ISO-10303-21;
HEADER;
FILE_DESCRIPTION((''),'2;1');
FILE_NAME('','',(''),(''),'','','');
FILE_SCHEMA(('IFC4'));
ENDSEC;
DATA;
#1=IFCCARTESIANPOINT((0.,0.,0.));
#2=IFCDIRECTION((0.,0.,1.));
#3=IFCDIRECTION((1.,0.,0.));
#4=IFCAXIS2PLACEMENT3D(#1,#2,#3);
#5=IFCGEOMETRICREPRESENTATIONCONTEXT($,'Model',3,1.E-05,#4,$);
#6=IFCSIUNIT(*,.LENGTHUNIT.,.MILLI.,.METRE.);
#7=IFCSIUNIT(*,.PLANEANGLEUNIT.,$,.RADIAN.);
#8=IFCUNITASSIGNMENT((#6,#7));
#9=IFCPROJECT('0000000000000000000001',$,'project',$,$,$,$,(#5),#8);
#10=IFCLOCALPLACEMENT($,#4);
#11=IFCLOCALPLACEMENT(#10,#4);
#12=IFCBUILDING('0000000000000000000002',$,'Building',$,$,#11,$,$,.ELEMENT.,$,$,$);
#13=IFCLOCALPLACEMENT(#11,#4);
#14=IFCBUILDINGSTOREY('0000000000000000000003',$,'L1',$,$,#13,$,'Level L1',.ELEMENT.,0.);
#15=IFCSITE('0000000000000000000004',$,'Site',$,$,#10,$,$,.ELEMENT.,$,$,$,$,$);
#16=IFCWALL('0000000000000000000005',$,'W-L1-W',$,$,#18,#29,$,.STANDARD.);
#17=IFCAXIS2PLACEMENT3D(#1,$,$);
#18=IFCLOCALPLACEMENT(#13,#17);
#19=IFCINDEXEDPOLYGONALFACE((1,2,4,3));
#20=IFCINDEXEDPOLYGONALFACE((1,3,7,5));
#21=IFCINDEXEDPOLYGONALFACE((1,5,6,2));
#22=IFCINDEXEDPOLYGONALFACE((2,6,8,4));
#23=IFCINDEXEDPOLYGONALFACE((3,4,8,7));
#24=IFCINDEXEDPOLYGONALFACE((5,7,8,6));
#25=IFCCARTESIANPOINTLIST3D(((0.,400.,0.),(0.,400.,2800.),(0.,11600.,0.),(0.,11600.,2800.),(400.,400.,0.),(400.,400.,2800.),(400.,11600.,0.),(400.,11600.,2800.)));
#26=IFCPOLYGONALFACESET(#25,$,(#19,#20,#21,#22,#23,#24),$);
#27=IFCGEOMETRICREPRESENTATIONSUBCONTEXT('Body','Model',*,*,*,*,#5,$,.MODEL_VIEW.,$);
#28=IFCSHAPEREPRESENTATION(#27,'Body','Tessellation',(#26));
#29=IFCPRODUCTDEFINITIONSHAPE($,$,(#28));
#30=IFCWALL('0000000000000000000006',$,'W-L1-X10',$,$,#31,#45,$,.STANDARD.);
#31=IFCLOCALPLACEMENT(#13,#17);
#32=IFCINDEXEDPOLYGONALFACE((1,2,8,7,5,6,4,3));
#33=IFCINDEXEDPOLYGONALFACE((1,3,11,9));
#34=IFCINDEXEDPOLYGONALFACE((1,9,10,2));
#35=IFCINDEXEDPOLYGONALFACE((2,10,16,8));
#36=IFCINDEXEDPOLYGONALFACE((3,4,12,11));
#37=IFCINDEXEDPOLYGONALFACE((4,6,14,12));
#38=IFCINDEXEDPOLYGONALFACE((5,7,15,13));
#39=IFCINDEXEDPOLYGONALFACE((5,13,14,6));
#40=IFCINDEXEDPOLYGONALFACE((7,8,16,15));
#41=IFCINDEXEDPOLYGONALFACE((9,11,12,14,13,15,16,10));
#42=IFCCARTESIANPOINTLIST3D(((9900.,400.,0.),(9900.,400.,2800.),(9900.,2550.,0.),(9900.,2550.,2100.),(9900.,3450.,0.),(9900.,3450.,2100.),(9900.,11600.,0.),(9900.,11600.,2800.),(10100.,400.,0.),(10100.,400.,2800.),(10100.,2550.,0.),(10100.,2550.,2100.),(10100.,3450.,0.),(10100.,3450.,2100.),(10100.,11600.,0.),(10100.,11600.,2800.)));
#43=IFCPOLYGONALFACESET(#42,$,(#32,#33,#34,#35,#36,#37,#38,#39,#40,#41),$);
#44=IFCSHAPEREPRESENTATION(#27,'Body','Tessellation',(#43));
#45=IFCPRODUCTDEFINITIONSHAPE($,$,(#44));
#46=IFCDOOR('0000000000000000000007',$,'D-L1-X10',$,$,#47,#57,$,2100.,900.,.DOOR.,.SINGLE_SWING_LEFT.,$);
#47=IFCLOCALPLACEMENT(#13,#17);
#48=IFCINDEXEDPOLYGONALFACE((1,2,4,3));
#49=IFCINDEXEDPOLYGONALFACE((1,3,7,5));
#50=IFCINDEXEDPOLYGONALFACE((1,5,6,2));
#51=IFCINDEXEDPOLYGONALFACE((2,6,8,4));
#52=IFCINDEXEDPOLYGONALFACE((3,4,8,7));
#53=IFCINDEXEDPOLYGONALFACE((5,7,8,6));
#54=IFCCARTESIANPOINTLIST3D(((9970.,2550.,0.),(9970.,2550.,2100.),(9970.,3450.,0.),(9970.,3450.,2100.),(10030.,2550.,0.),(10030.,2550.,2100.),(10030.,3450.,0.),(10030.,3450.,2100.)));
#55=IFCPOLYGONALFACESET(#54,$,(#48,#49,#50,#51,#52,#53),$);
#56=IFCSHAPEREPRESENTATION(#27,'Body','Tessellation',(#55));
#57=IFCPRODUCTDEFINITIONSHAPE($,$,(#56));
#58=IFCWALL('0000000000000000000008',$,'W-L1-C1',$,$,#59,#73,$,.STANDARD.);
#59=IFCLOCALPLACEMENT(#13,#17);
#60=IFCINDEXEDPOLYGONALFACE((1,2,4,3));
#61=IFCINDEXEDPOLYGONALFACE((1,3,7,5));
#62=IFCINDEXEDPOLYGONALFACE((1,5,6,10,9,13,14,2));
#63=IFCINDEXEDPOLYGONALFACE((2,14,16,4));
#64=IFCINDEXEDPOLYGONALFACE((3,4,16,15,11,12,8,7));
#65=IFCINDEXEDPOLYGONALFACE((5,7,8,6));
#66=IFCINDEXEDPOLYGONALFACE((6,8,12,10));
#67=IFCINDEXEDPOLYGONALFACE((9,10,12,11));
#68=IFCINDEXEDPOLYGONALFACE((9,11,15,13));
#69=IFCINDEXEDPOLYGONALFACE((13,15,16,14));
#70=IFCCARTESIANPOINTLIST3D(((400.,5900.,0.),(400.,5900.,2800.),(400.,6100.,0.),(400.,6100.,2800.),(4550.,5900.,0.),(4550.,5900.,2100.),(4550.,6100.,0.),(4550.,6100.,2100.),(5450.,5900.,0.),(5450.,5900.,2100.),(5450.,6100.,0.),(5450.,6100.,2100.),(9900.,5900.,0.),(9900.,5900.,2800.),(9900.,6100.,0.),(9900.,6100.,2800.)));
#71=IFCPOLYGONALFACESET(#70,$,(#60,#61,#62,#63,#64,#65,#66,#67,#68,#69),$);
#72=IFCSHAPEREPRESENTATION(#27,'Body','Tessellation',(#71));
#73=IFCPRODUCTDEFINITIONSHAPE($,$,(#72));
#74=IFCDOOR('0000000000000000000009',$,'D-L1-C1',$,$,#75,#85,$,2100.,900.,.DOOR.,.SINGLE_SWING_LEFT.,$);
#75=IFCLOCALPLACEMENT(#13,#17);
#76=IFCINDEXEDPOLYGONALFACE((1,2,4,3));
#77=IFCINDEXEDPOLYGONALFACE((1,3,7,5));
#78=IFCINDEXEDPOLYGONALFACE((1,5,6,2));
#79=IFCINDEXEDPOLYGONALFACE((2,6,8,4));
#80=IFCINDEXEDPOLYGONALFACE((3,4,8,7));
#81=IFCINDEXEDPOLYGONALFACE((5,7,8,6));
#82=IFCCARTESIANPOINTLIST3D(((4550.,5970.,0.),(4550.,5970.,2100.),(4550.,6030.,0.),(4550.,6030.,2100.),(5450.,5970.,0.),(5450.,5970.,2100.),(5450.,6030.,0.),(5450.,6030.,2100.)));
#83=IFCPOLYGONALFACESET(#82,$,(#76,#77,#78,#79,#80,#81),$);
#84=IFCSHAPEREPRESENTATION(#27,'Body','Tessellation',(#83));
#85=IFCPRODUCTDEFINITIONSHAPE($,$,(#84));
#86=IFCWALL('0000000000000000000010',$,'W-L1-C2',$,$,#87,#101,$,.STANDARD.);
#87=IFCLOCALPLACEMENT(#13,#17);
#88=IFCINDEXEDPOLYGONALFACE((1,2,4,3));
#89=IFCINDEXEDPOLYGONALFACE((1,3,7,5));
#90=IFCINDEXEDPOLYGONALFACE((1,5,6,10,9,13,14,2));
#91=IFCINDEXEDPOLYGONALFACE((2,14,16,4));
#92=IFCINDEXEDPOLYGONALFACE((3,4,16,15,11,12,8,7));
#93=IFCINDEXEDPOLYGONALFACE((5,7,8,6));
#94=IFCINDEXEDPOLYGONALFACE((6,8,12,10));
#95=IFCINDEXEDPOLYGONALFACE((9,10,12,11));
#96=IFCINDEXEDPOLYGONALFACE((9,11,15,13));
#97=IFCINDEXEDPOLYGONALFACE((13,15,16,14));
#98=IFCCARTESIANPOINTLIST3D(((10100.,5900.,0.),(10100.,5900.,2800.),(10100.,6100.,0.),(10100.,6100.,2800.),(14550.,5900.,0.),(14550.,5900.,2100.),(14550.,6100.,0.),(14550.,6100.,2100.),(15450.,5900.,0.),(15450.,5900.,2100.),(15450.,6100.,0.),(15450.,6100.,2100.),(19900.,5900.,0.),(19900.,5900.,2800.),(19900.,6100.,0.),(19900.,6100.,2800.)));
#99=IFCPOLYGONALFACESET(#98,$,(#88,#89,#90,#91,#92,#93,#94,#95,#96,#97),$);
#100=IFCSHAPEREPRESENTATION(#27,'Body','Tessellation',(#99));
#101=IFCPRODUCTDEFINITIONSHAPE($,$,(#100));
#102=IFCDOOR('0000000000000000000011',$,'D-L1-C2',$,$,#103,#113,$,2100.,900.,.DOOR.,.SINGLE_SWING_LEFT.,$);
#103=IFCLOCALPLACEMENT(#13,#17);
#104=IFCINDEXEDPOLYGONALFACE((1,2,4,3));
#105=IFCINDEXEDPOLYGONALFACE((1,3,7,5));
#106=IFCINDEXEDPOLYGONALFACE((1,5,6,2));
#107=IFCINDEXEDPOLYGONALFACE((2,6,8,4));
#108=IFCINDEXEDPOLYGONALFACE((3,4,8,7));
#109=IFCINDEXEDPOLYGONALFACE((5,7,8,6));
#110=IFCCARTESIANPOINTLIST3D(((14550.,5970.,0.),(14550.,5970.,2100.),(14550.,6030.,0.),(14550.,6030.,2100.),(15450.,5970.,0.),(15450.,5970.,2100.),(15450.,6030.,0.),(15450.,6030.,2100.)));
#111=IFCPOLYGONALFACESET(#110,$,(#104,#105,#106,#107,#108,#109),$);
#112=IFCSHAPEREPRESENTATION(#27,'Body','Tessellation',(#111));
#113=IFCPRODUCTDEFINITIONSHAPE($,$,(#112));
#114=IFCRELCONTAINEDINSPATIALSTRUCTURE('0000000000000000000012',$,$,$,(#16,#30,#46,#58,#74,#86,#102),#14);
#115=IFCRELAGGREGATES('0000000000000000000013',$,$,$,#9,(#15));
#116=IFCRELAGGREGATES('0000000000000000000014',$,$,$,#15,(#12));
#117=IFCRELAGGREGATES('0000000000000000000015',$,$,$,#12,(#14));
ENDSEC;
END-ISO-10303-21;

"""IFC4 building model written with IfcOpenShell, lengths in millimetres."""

from ifc_helpers import new_model, si_unit, frame, origin_with_axes, origin_2d, place, context, subcontext, project, spatial, rectangle, extrude, element, fill, save


model = new_model("IFC4")

# Units and contexts
model_context = context("Model", 3, precision=1e-05, world=origin_with_axes())
body_context = subcontext(model_context, "Body", "Model", "MODEL_VIEW")
ifc_project = project(units=[si_unit("LENGTHUNIT", "METRE", prefix="MILLI"), si_unit("PLANEANGLEUNIT", "RADIAN")], contexts=[model_context])

# Site, building, storey
site_placement = place(None, origin_with_axes())
site = spatial("IfcSite", under=ifc_project, at=site_placement, Name="Site", CompositionType="ELEMENT")
building_placement = place(site_placement, origin_with_axes())
building = spatial("IfcBuilding", under=site, at=building_placement, Name="Building", CompositionType="ELEMENT")
storey_placement = place(building_placement, origin_with_axes())
storey = spatial("IfcBuildingStorey", under=building, at=storey_placement, Name="L1", LongName="Level L1", CompositionType="ELEMENT", Elevation=0.0)

# Wall
wall_1_placement = place(storey_placement, frame((200.0, 6000.0, 0.0), z_axis=(0.0, 0.0, 1.0), x_axis=(1.0, 0.0, 0.0)))
element("IfcWall", 1, at=wall_1_placement, inside=storey, Name="W-L1-W", PredefinedType="STANDARD", context=body_context, shape_type="SweptSolid", body=[
    extrude(rectangle(XDim=400.0, YDim=11200.0, at=origin_2d()), origin_with_axes(), (0.0, 0.0, 1.0), 2800.0),
])

# Walls, openings, doors
wall_2_placement = place(storey_placement, frame((10000.0, 6000.0, 0.0), z_axis=(0.0, 0.0, 1.0), x_axis=(1.0, 0.0, 0.0)))
wall_2 = element("IfcWall", 2, at=wall_2_placement, inside=storey, Name="W-L1-X10", PredefinedType="STANDARD", context=body_context, shape_type="SweptSolid", body=[
    extrude(rectangle(XDim=200.0, YDim=11200.0, at=origin_2d()), origin_with_axes(), (0.0, 0.0, 1.0), 2800.0),
])
opening_1_placement = place(wall_2_placement, frame((0.0, -3000.0, 0.0), z_axis=(0.0, 0.0, 1.0), x_axis=(1.0, 0.0, 0.0)))
opening_1 = element("IfcOpeningElement", 3, at=opening_1_placement, cuts=wall_2, PredefinedType="OPENING", context=body_context, shape_type="SweptSolid", body=[
    extrude(rectangle(XDim=300.0, YDim=900.0, at=origin_2d()), origin_with_axes(), (0.0, 0.0, 1.0), 2100.0),
])
door_1_placement = place(wall_2_placement, frame((0.0, -3000.0, 0.0), z_axis=(0.0, 0.0, 1.0), x_axis=(1.0, 0.0, 0.0)))
door_1 = element("IfcDoor", 4, at=door_1_placement, inside=storey, Name="D-L1-X10", OperationType="SINGLE_SWING_LEFT", OverallHeight=2100.0, OverallWidth=900.0, PredefinedType="DOOR", context=body_context, shape_type="SweptSolid", body=[
    extrude(rectangle(XDim=60.0, YDim=900.0, at=origin_2d()), origin_with_axes(), (0.0, 0.0, 1.0), 2100.0),
])
fill(opening_1, door_1)
wall_3_placement = place(storey_placement, frame((5150.0, 6000.0, 0.0), z_axis=(0.0, 0.0, 1.0), x_axis=(1.0, 0.0, 0.0)))
wall_3 = element("IfcWall", 5, at=wall_3_placement, inside=storey, Name="W-L1-C1", PredefinedType="STANDARD", context=body_context, shape_type="SweptSolid", body=[
    extrude(rectangle(XDim=9500.0, YDim=200.0, at=origin_2d()), origin_with_axes(), (0.0, 0.0, 1.0), 2800.0),
])
opening_2_placement = place(wall_3_placement, frame((-150.0, 0.0, 0.0), z_axis=(0.0, 0.0, 1.0), x_axis=(1.0, 0.0, 0.0)))
opening_2 = element("IfcOpeningElement", 6, at=opening_2_placement, cuts=wall_3, PredefinedType="OPENING", context=body_context, shape_type="SweptSolid", body=[
    extrude(rectangle(XDim=900.0, YDim=300.0, at=origin_2d()), origin_with_axes(), (0.0, 0.0, 1.0), 2100.0),
])
door_2_placement = place(wall_3_placement, frame((-150.0, 0.0, 0.0), z_axis=(0.0, 0.0, 1.0), x_axis=(1.0, 0.0, 0.0)))
door_2 = element("IfcDoor", 7, at=door_2_placement, inside=storey, Name="D-L1-C1", OperationType="SINGLE_SWING_LEFT", OverallHeight=2100.0, OverallWidth=900.0, PredefinedType="DOOR", context=body_context, shape_type="SweptSolid", body=[
    extrude(rectangle(XDim=900.0, YDim=60.0, at=origin_2d()), origin_with_axes(), (0.0, 0.0, 1.0), 2100.0),
])
fill(opening_2, door_2)
wall_4_placement = place(storey_placement, frame((15000.0, 6000.0, 0.0), z_axis=(0.0, 0.0, 1.0), x_axis=(1.0, 0.0, 0.0)))
wall_4 = element("IfcWall", 8, at=wall_4_placement, inside=storey, Name="W-L1-C2", PredefinedType="STANDARD", context=body_context, shape_type="SweptSolid", body=[
    extrude(rectangle(XDim=9800.0, YDim=200.0, at=origin_2d()), origin_with_axes(), (0.0, 0.0, 1.0), 2800.0),
])
opening_3_placement = place(wall_4_placement, origin_with_axes())
opening_3 = element("IfcOpeningElement", 9, at=opening_3_placement, cuts=wall_4, PredefinedType="OPENING", context=body_context, shape_type="SweptSolid", body=[
    extrude(rectangle(XDim=900.0, YDim=300.0, at=origin_2d()), origin_with_axes(), (0.0, 0.0, 1.0), 2100.0),
])
door_3_placement = place(wall_4_placement, origin_with_axes())
door_3 = element("IfcDoor", 10, at=door_3_placement, inside=storey, Name="D-L1-C2", OperationType="SINGLE_SWING_LEFT", OverallHeight=2100.0, OverallWidth=900.0, PredefinedType="DOOR", context=body_context, shape_type="SweptSolid", body=[
    extrude(rectangle(XDim=900.0, YDim=60.0, at=origin_2d()), origin_with_axes(), (0.0, 0.0, 1.0), 2100.0),
])
fill(opening_3, door_3)

save(model, "model.ifc")
